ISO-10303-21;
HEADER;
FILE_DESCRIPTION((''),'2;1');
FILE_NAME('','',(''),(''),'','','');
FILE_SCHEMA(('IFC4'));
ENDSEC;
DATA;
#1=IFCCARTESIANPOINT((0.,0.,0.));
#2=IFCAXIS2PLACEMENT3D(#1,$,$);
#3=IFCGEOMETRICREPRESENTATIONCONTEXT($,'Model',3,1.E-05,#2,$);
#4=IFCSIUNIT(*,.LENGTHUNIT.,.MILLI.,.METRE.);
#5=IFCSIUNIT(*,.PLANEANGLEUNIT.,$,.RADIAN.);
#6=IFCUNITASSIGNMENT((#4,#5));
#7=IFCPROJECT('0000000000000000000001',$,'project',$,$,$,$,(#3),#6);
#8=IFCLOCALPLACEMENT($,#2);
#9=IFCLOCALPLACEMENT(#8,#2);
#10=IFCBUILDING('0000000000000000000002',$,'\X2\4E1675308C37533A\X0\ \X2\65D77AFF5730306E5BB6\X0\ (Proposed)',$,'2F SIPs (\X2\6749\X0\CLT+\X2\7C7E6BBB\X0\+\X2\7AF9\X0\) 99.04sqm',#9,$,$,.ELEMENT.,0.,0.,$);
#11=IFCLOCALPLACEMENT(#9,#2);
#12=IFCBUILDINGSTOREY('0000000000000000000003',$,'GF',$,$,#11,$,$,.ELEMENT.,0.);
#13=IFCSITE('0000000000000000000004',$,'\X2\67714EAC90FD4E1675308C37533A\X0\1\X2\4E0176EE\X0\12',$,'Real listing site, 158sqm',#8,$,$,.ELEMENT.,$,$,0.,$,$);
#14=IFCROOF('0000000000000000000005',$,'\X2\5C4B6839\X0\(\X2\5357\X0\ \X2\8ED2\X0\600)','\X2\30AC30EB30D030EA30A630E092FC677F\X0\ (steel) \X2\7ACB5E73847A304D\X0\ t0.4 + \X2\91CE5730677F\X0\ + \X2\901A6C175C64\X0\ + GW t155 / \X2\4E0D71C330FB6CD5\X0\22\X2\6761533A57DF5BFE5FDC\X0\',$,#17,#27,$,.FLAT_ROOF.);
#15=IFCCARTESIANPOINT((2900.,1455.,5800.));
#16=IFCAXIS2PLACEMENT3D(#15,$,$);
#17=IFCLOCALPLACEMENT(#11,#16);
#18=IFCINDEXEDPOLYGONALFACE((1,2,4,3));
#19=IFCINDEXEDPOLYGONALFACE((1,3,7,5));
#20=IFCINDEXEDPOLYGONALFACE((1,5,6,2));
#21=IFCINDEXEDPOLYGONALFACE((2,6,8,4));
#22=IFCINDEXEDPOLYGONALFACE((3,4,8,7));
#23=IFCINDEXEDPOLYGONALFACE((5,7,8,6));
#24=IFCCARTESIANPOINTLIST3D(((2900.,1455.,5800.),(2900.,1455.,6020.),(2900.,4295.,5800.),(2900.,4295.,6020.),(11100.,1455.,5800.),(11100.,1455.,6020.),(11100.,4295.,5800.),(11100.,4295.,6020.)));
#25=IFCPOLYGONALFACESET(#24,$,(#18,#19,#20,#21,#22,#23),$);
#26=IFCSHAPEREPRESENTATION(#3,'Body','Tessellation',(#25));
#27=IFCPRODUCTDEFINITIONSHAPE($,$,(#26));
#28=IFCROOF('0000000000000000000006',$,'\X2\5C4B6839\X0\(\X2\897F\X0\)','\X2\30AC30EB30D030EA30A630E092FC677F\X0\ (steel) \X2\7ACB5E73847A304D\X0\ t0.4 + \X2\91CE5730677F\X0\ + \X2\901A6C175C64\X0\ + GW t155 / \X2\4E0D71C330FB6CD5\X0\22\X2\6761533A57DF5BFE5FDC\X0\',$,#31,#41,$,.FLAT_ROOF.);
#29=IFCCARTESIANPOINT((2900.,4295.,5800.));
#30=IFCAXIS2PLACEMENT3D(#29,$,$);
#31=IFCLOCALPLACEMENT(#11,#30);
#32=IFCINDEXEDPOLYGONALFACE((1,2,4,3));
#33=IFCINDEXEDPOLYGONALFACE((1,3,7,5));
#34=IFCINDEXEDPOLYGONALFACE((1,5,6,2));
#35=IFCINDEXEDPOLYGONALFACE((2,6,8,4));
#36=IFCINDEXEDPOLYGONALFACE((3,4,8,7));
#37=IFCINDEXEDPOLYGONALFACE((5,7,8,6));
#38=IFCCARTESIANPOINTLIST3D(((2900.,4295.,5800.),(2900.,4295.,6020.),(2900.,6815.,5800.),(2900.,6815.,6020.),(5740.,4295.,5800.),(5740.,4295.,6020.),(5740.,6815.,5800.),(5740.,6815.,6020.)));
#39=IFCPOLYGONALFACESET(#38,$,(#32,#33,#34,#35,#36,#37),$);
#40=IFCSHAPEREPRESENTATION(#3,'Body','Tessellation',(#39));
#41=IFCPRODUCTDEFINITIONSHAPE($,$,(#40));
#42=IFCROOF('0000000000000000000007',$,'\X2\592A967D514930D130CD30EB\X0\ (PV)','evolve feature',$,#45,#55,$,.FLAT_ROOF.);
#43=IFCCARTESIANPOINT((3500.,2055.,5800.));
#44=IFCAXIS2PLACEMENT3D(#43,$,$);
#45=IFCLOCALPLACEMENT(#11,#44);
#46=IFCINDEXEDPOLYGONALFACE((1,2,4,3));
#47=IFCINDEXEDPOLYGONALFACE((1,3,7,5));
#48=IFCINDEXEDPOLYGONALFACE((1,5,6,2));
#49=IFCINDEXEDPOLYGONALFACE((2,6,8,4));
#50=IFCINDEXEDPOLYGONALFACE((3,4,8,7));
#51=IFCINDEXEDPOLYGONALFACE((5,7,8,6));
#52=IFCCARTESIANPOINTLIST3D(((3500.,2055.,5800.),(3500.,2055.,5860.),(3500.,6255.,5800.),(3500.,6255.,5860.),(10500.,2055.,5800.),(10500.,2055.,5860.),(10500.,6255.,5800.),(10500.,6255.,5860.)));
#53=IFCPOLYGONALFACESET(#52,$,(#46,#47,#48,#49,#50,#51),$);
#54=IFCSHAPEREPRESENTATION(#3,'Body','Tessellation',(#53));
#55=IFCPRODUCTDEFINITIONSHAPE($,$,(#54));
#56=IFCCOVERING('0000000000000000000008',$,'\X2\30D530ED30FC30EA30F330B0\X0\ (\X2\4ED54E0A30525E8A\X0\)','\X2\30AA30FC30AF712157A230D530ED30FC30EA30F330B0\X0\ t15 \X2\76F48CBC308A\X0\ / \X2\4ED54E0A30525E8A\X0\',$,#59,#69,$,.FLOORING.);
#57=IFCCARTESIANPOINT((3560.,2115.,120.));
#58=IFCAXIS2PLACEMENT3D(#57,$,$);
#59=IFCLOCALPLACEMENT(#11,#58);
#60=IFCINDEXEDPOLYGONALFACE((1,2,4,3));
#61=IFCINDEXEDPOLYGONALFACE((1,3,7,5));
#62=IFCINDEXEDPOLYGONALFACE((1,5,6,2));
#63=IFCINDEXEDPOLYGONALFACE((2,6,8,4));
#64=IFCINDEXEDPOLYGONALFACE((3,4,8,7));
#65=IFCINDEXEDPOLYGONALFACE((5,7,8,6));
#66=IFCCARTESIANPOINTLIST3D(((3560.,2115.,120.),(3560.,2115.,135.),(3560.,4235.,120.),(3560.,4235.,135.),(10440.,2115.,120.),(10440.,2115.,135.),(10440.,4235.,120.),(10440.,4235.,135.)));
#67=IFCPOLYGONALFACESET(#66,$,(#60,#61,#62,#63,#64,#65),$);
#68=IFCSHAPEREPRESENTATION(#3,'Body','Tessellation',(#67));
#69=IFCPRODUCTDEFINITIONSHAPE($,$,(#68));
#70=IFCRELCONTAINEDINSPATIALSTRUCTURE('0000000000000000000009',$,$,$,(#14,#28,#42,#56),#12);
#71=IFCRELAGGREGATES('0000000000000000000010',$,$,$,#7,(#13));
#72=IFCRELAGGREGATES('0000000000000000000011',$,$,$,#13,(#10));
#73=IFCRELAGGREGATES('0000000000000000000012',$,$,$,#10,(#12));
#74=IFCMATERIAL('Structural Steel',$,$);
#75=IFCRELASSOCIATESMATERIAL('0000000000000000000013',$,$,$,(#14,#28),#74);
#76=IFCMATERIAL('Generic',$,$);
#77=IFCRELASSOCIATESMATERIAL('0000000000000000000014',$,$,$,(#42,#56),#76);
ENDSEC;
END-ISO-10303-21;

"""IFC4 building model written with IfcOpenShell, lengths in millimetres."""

from ifc_helpers import new_model, si_unit, frame, frame_2d, origin, place, context, project, spatial, rectangle, extrude, material, element, save


model = new_model("IFC4")

# Units and contexts
model_context = context("Model", 3, precision=1e-05, world=origin())
ifc_project = project(units=[si_unit("LENGTHUNIT", "METRE", prefix="MILLI"), si_unit("PLANEANGLEUNIT", "RADIAN")], contexts=[model_context])

# Site, building, storey
site_placement = place(None, origin())
site = spatial("IfcSite", under=ifc_project, at=site_placement, Name="東京都世田谷区1丁目12", ObjectType="Real listing site, 158sqm", CompositionType="ELEMENT", RefElevation=0.0)
building_placement = place(site_placement, origin())
building = spatial("IfcBuilding", under=site, at=building_placement, Name="世田谷区 旗竿地の家 (Proposed)", ObjectType="2F SIPs (杉CLT+籾殻+竹) 99.04sqm", CompositionType="ELEMENT", ElevationOfRefHeight=0.0, ElevationOfTerrain=0.0)
storey_placement = place(building_placement, origin())
storey = spatial("IfcBuildingStorey", under=building, at=storey_placement, Name="GF", CompositionType="ELEMENT", Elevation=0.0)

# Shared definitions
ifc_material_1 = material(Name="Generic")

# Roofs
ifc_material_2 = material(Name="Structural Steel")
roof_1_placement = place(storey_placement, frame((2900.0, 1455.0, 5800.0)))
element("IfcRoof", 1, at=roof_1_placement, inside=storey, material=ifc_material_2, Name="屋根(南 軒600)", Description="ガルバリウム鋼板 (steel) 立平葺き t0.4 + 野地板 + 通気層 + GW t155 / 不燃・法22条区域対応", PredefinedType="FLAT_ROOF", context=model_context, shape_type="SweptSolid", body=[
    extrude(rectangle(XDim=8200.0, YDim=2840.0, at=frame_2d((4100.0, 1420.0))), frame((2900.0, 1455.0, 5800.0)), (0.0, 0.0, 1.0), 220.0),
])
roof_2_placement = place(storey_placement, frame((2900.0, 4295.0, 5800.0)))
element("IfcRoof", 2, at=roof_2_placement, inside=storey, material=ifc_material_2, Name="屋根(西)", Description="ガルバリウム鋼板 (steel) 立平葺き t0.4 + 野地板 + 通気層 + GW t155 / 不燃・法22条区域対応", PredefinedType="FLAT_ROOF", context=model_context, shape_type="SweptSolid", body=[
    extrude(rectangle(XDim=2840.0, YDim=2520.0, at=frame_2d((1420.0, 1260.0))), frame((2900.0, 4295.0, 5800.0)), (0.0, 0.0, 1.0), 220.0),
])
roof_3_placement = place(storey_placement, frame((3500.0, 2055.0, 5800.0)))
element("IfcRoof", 3, at=roof_3_placement, inside=storey, material=ifc_material_1, Name="太陽光パネル (PV)", Description="evolve feature", PredefinedType="FLAT_ROOF", context=model_context, shape_type="SweptSolid", body=[
    extrude(rectangle(XDim=7000.0, YDim=4200.0, at=frame_2d((3500.0, 2100.0))), frame((3500.0, 2055.0, 5800.0)), (0.0, 0.0, 1.0), 60.0),
])

# Covering
covering_placement = place(storey_placement, frame((3560.0, 2115.0, 120.0)))
element("IfcCovering", 4, at=covering_placement, inside=storey, material=ifc_material_1, Name="フローリング (仕上げ床)", Description="オーク無垢フローリング t15 直貼り / 仕上げ床", PredefinedType="FLOORING", context=model_context, shape_type="SweptSolid", body=[
    extrude(rectangle(XDim=6880.0, YDim=2120.0, at=frame_2d((3440.0, 1060.0))), frame((3560.0, 2115.0, 120.0)), (0.0, 0.0, 1.0), 15.0),
])

save(model, "model.ifc")
